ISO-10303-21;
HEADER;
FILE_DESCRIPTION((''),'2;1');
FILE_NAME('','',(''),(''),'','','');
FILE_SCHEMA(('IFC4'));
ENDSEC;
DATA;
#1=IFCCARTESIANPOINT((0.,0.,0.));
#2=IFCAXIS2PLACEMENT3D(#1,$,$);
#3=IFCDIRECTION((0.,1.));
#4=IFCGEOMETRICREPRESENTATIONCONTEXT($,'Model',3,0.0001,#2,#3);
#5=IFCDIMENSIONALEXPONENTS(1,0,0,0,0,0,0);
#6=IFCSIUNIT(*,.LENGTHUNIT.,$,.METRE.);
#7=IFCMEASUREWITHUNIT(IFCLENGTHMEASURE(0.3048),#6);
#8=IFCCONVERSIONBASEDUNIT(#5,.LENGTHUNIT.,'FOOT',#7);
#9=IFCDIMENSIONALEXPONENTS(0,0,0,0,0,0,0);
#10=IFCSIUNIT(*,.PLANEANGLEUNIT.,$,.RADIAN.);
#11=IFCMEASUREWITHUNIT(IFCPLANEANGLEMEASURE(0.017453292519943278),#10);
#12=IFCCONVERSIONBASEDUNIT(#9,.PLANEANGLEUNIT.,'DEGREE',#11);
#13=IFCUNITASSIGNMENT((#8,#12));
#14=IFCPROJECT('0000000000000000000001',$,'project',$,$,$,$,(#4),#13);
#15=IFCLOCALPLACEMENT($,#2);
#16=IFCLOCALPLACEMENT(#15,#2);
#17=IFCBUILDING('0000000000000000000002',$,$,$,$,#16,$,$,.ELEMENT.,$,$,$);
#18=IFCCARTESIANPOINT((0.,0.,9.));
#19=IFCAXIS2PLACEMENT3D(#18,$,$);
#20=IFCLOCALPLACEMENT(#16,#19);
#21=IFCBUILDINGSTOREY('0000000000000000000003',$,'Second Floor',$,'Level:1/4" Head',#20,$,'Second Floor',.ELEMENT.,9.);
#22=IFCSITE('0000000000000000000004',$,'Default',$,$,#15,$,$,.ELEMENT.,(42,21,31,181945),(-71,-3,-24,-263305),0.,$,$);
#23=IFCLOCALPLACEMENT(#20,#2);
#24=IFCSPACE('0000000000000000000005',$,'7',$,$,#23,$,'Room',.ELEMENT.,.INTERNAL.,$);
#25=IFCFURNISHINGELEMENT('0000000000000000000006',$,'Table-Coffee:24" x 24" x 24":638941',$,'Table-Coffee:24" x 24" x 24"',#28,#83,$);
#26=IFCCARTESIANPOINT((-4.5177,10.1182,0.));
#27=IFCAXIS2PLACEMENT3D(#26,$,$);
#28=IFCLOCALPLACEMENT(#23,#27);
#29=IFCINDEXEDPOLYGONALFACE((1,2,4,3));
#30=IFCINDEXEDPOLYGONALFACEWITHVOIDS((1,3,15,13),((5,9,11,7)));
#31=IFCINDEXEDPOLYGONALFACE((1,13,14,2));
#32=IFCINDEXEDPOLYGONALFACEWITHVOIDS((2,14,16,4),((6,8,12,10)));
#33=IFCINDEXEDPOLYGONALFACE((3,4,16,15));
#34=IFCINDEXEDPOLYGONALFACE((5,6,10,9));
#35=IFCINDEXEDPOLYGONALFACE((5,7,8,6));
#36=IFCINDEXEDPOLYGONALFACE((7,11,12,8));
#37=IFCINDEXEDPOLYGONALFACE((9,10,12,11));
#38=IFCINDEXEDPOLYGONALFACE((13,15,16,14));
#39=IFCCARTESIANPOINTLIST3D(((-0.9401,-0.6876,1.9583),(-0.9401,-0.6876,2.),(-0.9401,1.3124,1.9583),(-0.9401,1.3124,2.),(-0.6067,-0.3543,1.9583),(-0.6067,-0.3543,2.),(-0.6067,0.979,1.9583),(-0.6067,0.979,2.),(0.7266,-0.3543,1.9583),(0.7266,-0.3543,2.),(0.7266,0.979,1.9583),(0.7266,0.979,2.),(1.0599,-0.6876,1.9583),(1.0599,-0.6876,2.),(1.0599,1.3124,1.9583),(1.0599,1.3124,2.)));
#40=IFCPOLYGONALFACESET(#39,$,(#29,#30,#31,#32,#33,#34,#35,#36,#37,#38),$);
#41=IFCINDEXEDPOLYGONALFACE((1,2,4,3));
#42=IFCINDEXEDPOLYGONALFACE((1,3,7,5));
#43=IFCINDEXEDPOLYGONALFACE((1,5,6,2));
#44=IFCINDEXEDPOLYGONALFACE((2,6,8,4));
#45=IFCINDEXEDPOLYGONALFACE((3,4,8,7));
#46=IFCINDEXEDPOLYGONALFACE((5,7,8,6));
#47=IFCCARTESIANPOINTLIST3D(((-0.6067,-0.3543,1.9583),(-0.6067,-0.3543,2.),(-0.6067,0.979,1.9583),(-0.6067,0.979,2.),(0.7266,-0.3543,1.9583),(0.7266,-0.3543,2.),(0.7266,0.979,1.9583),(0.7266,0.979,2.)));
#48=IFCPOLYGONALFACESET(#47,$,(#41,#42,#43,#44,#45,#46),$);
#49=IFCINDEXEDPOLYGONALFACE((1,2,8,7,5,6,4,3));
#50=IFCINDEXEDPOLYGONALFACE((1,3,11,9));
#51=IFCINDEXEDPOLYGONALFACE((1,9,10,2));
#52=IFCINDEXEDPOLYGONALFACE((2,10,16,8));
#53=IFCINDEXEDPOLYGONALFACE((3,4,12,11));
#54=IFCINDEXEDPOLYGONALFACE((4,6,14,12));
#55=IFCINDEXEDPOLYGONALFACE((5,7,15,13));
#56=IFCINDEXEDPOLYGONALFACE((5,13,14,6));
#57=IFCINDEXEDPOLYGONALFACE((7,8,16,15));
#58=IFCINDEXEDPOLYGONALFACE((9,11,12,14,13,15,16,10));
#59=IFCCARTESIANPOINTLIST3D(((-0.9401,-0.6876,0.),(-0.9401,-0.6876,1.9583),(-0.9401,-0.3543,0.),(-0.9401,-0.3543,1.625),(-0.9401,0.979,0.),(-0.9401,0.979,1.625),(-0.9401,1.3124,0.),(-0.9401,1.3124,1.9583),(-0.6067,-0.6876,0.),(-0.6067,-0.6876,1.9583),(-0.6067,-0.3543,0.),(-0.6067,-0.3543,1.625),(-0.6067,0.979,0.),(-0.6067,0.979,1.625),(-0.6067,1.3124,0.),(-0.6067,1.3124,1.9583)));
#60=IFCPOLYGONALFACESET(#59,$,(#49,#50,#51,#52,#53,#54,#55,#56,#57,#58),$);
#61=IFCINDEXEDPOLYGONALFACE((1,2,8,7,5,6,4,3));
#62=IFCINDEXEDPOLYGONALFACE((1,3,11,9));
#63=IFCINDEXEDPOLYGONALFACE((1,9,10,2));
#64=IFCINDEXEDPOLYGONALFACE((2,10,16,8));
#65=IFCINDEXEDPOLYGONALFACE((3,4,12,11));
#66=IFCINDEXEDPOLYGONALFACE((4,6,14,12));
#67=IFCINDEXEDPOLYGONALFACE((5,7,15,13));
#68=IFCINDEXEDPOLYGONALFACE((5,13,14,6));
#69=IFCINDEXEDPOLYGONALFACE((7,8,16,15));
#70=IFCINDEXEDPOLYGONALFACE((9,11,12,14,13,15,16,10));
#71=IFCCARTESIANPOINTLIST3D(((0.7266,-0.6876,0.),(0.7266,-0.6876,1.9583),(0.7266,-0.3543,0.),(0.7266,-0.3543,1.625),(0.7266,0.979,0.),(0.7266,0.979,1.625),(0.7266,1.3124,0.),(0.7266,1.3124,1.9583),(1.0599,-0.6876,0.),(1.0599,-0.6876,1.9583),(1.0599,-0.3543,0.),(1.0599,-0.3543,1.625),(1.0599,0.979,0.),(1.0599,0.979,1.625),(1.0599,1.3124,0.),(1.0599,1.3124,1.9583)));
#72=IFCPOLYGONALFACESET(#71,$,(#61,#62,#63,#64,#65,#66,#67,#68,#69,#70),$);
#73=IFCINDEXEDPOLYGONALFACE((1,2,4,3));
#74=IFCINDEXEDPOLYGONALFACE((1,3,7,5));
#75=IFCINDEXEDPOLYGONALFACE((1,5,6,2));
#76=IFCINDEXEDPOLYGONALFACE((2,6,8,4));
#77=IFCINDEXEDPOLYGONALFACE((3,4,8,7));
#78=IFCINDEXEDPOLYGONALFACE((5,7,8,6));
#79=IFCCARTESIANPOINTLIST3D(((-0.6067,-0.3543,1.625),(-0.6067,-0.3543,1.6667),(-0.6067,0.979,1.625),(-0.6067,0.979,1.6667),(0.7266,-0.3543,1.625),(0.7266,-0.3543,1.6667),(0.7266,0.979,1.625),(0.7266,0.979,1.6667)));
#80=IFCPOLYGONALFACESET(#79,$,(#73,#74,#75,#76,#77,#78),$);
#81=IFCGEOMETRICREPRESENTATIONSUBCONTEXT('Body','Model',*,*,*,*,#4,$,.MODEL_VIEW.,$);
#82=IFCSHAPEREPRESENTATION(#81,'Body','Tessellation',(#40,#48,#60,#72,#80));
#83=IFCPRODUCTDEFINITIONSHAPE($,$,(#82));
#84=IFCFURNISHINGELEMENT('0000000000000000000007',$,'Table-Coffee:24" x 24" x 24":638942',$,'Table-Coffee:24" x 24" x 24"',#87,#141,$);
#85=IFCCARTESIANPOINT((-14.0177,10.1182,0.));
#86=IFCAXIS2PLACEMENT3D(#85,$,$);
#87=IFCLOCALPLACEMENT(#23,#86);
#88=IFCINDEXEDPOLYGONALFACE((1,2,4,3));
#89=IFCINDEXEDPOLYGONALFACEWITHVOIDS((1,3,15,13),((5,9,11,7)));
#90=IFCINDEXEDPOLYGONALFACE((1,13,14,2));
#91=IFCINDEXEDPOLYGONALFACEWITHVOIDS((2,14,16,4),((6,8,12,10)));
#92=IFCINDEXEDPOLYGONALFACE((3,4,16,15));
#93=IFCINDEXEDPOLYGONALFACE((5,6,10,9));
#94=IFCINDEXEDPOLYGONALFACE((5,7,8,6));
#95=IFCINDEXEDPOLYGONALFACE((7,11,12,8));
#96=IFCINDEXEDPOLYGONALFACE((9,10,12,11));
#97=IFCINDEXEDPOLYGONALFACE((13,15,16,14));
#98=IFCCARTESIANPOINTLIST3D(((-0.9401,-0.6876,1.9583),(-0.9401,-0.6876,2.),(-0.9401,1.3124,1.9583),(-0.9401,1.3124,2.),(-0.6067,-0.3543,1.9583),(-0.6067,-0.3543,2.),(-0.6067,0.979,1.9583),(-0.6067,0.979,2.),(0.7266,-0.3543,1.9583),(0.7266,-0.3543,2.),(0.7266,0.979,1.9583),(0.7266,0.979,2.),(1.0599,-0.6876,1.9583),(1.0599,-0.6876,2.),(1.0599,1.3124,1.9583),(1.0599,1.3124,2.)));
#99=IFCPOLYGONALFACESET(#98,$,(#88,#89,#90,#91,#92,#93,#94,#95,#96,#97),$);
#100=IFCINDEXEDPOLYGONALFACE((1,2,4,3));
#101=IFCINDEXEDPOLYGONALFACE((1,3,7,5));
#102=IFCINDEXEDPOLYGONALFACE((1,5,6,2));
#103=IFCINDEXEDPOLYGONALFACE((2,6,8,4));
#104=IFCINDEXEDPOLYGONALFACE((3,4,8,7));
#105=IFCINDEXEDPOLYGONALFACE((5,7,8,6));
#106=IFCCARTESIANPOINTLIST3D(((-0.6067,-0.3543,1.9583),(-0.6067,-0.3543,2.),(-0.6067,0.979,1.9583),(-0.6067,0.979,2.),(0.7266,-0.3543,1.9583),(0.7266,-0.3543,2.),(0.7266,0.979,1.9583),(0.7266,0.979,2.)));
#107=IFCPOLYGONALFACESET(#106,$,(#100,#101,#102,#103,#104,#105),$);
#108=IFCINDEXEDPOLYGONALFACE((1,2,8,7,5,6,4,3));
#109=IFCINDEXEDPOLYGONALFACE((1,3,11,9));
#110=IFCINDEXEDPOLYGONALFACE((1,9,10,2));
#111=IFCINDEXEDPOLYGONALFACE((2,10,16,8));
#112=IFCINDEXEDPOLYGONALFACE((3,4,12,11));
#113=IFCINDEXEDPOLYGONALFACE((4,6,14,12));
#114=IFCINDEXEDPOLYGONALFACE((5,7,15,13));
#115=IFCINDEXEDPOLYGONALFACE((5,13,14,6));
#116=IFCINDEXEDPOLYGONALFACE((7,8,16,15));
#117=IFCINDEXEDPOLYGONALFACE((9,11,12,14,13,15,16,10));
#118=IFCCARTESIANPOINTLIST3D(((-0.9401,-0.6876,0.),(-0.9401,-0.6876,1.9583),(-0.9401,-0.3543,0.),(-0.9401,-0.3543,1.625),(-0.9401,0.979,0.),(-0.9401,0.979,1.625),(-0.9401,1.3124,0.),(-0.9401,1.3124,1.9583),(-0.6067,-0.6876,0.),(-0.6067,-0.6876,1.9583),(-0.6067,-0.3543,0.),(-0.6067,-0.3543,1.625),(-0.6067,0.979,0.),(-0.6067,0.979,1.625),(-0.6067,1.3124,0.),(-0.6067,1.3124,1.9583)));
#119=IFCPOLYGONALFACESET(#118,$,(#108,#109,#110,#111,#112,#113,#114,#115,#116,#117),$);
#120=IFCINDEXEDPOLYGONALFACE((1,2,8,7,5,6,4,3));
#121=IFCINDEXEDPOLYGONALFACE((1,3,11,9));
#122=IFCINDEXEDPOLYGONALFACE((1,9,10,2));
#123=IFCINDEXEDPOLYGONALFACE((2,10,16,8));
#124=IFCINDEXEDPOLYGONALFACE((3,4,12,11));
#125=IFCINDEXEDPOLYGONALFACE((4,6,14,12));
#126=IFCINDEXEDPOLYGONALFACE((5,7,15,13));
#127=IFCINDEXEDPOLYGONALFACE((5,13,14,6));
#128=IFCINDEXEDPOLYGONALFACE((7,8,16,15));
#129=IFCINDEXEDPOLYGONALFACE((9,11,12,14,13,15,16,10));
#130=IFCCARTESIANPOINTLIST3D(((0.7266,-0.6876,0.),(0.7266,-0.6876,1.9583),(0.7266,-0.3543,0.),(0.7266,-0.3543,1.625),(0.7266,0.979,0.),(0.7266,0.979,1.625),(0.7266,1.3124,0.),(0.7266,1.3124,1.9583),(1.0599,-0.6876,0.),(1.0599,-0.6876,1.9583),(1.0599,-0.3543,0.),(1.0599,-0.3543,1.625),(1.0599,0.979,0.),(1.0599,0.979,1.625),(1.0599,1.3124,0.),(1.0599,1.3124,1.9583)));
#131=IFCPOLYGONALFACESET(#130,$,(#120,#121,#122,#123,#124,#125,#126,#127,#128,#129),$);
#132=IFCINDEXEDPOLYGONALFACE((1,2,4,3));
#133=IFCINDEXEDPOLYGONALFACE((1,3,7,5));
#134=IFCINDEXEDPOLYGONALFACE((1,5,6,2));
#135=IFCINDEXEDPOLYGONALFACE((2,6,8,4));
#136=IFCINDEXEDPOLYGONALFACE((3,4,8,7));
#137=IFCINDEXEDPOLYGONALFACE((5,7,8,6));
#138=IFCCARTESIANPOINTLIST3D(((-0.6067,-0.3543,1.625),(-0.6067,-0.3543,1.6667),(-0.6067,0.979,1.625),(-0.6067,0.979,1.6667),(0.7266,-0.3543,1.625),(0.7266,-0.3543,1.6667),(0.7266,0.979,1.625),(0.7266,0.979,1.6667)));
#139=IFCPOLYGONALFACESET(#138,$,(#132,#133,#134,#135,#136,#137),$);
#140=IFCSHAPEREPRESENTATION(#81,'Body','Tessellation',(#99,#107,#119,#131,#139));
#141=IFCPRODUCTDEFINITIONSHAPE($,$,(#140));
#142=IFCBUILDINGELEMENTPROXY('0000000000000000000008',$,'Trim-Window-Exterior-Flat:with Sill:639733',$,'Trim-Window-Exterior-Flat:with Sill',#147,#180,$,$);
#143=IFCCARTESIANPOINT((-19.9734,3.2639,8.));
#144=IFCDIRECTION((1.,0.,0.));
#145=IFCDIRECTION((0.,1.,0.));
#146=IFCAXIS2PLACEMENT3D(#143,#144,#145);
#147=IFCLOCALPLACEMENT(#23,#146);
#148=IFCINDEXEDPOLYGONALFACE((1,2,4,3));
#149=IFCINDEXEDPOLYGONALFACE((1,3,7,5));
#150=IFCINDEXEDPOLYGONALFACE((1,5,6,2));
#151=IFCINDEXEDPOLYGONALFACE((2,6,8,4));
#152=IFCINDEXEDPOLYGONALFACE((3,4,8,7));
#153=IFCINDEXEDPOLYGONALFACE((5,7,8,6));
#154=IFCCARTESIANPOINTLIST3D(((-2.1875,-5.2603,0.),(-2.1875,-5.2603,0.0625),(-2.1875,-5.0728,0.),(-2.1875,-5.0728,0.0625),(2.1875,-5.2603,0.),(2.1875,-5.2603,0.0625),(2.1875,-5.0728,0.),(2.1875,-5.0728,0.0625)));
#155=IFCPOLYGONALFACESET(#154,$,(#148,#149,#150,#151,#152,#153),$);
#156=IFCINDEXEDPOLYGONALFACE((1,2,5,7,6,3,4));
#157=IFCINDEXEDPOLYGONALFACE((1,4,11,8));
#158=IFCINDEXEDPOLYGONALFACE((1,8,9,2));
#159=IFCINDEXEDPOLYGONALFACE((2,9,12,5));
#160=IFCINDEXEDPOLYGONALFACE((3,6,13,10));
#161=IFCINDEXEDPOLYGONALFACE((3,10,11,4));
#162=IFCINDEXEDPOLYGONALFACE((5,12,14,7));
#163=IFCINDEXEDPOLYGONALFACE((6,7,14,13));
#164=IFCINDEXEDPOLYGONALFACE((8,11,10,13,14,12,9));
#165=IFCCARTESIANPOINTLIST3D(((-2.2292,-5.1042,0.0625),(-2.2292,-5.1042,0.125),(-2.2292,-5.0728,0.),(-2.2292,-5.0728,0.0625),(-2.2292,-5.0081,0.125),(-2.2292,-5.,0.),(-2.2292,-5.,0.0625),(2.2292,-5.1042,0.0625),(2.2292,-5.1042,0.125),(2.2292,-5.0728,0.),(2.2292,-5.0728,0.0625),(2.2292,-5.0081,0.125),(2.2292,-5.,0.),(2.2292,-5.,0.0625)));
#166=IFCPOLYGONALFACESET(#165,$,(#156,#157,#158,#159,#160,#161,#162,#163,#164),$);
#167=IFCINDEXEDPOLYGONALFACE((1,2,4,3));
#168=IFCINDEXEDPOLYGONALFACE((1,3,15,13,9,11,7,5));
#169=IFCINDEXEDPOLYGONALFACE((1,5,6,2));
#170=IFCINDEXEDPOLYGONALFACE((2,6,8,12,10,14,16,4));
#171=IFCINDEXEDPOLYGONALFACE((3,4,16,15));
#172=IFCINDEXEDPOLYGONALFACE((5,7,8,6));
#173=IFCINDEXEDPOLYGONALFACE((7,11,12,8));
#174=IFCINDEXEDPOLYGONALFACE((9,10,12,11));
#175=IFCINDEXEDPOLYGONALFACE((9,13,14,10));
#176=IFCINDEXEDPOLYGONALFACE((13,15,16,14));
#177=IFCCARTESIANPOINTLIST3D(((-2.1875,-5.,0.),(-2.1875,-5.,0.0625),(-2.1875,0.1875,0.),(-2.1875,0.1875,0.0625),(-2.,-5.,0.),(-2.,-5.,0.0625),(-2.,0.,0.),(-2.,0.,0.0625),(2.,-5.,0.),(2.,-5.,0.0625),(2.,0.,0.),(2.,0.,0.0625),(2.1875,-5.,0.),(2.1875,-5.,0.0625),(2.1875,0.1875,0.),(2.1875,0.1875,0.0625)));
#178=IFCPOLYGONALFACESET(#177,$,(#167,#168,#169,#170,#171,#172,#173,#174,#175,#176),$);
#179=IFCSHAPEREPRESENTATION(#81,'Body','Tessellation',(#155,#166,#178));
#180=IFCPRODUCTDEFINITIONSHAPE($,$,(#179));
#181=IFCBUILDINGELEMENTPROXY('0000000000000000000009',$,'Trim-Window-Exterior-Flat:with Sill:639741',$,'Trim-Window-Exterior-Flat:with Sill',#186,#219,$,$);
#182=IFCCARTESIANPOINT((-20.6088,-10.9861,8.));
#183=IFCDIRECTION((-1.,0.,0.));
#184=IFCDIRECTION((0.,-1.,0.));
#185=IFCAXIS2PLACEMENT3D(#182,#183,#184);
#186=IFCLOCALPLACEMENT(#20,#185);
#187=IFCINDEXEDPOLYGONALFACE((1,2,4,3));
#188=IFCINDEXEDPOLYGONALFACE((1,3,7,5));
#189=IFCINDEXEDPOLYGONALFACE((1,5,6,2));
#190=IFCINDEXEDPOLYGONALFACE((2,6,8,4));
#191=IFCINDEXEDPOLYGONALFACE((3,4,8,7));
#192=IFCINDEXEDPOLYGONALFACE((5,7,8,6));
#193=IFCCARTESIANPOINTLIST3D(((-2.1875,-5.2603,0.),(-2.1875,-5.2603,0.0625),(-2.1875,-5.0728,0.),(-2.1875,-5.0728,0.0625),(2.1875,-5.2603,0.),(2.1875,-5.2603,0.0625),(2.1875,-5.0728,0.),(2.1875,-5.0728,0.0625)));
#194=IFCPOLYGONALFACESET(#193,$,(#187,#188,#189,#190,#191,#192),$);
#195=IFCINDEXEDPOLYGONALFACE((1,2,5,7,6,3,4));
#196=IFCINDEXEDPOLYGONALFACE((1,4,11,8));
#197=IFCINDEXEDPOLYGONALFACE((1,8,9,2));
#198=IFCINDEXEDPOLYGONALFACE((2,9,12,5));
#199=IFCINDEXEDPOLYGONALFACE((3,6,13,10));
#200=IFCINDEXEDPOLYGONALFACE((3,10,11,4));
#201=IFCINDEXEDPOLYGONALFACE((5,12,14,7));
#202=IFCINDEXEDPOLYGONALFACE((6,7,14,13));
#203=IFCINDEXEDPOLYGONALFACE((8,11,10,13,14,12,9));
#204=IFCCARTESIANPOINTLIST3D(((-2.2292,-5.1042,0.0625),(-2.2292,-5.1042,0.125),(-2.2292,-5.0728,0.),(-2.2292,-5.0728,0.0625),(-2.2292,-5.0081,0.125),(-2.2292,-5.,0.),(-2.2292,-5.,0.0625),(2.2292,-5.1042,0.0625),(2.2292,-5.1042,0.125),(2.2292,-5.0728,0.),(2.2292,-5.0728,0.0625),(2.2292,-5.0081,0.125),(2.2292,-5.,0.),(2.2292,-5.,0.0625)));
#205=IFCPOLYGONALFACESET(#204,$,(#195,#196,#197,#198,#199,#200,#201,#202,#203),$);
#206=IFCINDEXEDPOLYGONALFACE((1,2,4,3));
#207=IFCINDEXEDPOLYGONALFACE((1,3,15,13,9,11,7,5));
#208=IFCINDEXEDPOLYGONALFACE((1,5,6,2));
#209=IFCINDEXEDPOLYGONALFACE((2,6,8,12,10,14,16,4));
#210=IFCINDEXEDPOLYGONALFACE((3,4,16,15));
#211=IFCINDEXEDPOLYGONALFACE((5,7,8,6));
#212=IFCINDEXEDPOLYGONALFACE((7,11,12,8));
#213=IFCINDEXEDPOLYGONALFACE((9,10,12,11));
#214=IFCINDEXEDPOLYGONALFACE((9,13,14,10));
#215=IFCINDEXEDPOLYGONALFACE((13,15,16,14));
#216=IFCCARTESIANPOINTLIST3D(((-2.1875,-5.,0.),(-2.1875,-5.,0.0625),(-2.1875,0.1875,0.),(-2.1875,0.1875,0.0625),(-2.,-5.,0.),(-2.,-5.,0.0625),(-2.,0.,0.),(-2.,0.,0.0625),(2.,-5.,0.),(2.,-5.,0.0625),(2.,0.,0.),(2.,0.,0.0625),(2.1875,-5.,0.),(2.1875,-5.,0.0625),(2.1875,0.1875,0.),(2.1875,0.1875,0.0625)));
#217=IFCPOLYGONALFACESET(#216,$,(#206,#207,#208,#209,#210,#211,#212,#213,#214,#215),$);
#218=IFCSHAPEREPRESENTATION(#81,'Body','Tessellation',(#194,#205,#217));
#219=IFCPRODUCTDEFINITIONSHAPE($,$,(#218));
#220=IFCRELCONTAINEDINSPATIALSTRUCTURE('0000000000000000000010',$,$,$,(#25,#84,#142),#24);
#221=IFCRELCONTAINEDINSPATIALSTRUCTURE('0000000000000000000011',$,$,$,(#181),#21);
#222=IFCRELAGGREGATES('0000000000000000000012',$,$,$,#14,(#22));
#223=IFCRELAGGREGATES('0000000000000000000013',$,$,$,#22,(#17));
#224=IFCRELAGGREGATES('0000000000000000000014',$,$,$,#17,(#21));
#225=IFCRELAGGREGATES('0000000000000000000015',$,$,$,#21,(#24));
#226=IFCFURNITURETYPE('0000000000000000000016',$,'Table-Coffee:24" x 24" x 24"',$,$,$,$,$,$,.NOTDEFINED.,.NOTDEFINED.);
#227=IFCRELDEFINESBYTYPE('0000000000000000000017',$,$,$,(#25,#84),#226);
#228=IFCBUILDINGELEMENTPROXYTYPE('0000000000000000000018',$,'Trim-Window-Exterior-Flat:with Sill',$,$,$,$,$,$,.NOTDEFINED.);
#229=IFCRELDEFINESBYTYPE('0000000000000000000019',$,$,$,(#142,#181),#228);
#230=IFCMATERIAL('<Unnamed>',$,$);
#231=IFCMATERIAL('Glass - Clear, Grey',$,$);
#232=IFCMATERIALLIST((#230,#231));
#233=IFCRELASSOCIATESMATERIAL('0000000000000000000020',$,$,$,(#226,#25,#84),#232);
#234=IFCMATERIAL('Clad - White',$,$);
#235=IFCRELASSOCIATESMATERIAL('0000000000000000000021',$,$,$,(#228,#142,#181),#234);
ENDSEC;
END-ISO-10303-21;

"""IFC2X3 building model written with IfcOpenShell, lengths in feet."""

from ifc_helpers import new_model, entity, si_unit, converted_unit, direction, frame, frame_2d, origin, origin_2d_with_axis, place, context, subcontext, project, spatial, polyline, rectangle, outline, extrude, source, transform, mapped, material, material_list, type_object, type_shapes, element, save


model = new_model("IFC2X3")

# Units and contexts
model_context = context("Model", 3, precision=0.0001, world=origin(), true_north=direction((0.0, 1.0)))
body_context = subcontext(model_context, "Body", "Model", "MODEL_VIEW")
ifc_project = project(units=[converted_unit("LENGTHUNIT", "FOOT", entity("IfcLengthMeasure", 0.3048), si_unit("LENGTHUNIT", "METRE"), dimensions=[1, 0, 0, 0, 0, 0, 0]), converted_unit("PLANEANGLEUNIT", "DEGREE", entity("IfcPlaneAngleMeasure", 0.017453292519943278), si_unit("PLANEANGLEUNIT", "RADIAN"), dimensions=[0, 0, 0, 0, 0, 0, 0])], contexts=[model_context])

# Site, building, storey
site_placement = place(None, origin())
site = spatial("IfcSite", under=ifc_project, at=site_placement, Name="Default", CompositionType="ELEMENT", RefLatitude=(42, 21, 31, 181945), RefLongitude=(-71, -3, -24, -263305), RefElevation=0.0)
building_placement = place(site_placement, origin())
building = spatial("IfcBuilding", under=site, at=building_placement, CompositionType="ELEMENT")
storey_placement = place(building_placement, frame((0.0, 0.0, 9.0)))
storey = spatial("IfcBuildingStorey", under=building, at=storey_placement, Name="Second Floor", ObjectType="Level:1/4\" Head", LongName="Second Floor", CompositionType="ELEMENT", Elevation=9.0)

# Shared definitions
space_placement = place(storey_placement, origin())
space = spatial("IfcSpace", under=storey, at=space_placement, Name="7", LongName="Room", CompositionType="ELEMENT", InteriorOrExteriorSpace="INTERNAL")

# Furnishing elements
ifc_material_1 = material(Name="<Unnamed>")
ifc_material_2 = material(Name="Glass - Clear, Grey")
ifc_material_list_1 = material_list([ifc_material_1, ifc_material_2])
furniture_type_1 = type_object("IfcFurnitureType", Name="Table-Coffee:24\" x 24\" x 24\"", AssemblyPlace="NOTDEFINED", material=ifc_material_list_1)
shared_shape_1 = source(origin(), body_context, "Body", "SweptSolid", [
    extrude(outline(polyline([(-1.0, -1.0), (1.0, -1.0), (1.0, 1.0), (-1.0, 1.0), (-1.0, -1.0)]), holes=[polyline([(-0.6667, -0.6667), (-0.6667, 0.6667), (0.6667, 0.6667), (0.6667, -0.6667), (-0.6667, -0.6667)])]), frame((0.0599, 0.3124, 1.9583), z_axis=(0.0, 0.0, 1.0), x_axis=(-1.0, 0.0, 0.0)), (0.0, 0.0, 1.0), 0.0417),
    extrude(rectangle(XDim=1.3333, YDim=1.3333, at=origin_2d_with_axis()), frame((0.0599, 0.3124, 1.9583), z_axis=(0.0, 0.0, 1.0), x_axis=(-1.0, 0.0, 0.0)), (0.0, 0.0, 1.0), 0.0417),
    extrude(outline(polyline([(-1.0, -1.0625), (1.0, -1.0625), (1.0, 0.8958), (0.6667, 0.8958), (0.6667, -0.7292), (-0.6667, -0.7292), (-0.6667, 0.8958), (-1.0, 0.8958), (-1.0, -1.0625)])), frame((-0.9401, 0.3124, 0.8958), z_axis=(1.0, 0.0, 0.0), x_axis=(0.0, -1.0, 0.0)), (0.0, 0.0, 1.0), 0.3333),
    extrude(outline(polyline([(-0.8958, -1.0), (1.0625, -1.0), (1.0625, 1.0), (-0.8958, 1.0), (-0.8958, 0.6667), (0.7292, 0.6667), (0.7292, -0.6667), (-0.8958, -0.6667), (-0.8958, -1.0)])), frame((0.7266, 0.3124, 0.8958), z_axis=(1.0, 0.0, 0.0), x_axis=(0.0, 0.0, 1.0)), (0.0, 0.0, 1.0), 0.3333),
    extrude(rectangle(XDim=1.3333, YDim=1.3333, at=origin_2d_with_axis()), frame((0.0599, 0.3124, 1.625), z_axis=(0.0, 0.0, 1.0), x_axis=(-1.0, 0.0, 0.0)), (0.0, 0.0, 1.0), 0.0417),
])
type_shapes(furniture_type_1, [shared_shape_1])
for number, where, name in (
    (1, (-4.5177, 10.1182, 0.0), "Table-Coffee:24\" x 24\" x 24\":638941"),
    (2, (-14.0177, 10.1182, 0.0), "Table-Coffee:24\" x 24\" x 24\":638942"),
):
    element("IfcFurnishingElement", number, at=place(space_placement, frame(where)), inside=space, type_object=furniture_type_1, material=ifc_material_list_1, Name=name, ObjectType="Table-Coffee:24\" x 24\" x 24\"", context=body_context, shape_type="MappedRepresentation", body=[
        mapped(shared_shape_1, transform((0.0, 0.0, 0.0), scale=1.0)),
    ])

# Building element proxies
ifc_material_3 = material(Name="Clad - White")
building_element_proxy_type_1 = type_object("IfcBuildingElementProxyType", Name="Trim-Window-Exterior-Flat:with Sill", PredefinedType="NOTDEFINED", material=ifc_material_3)
shared_shape_2 = source(origin(), body_context, "Body", "SweptSolid", [
    extrude(rectangle(XDim=4.375, YDim=0.1875, at=frame_2d((0.0, 0.0), x_axis=(1.0, 0.0))), frame((0.0, -5.1665, 0.0), z_axis=(0.0, 0.0, 1.0), x_axis=(-1.0, 0.0, 0.0)), (0.0, 0.0, 1.0), 0.0625),
    extrude(outline(polyline([(-0.0625, -0.0525), (0.0, -0.0525), (0.0, -0.0211), (0.0625, -0.0211), (0.0625, 0.0517), (0.0, 0.0517), (-0.0625, 0.0436), (-0.0625, -0.0525)])), frame((-2.2292, -5.0517, 0.0625), z_axis=(1.0, 0.0, 0.0), x_axis=(0.0, 0.0, -1.0)), (0.0, 0.0, 1.0), 4.4583),
    extrude(outline(polyline([(-2.6406, -2.1875), (2.5469, -2.1875), (2.5469, -2.0), (-2.4531, -2.0), (-2.4531, 2.0), (2.5469, 2.0), (2.5469, 2.1875), (-2.6406, 2.1875), (-2.6406, -2.1875)])), frame((0.0, -2.4531, 0.0), z_axis=(0.0, 0.0, 1.0), x_axis=(0.0, -1.0, 0.0)), (0.0, 0.0, 1.0), 0.0625),
])
type_shapes(building_element_proxy_type_1, [shared_shape_2])
proxy_1_placement = place(space_placement, frame((-19.9734, 3.2639, 8.0), z_axis=(1.0, 0.0, 0.0), x_axis=(0.0, 1.0, 0.0)))
element("IfcBuildingElementProxy", 3, at=proxy_1_placement, inside=space, type_object=building_element_proxy_type_1, material=ifc_material_3, Name="Trim-Window-Exterior-Flat:with Sill:639733", ObjectType="Trim-Window-Exterior-Flat:with Sill", context=body_context, shape_type="MappedRepresentation", body=[
    mapped(shared_shape_2, transform((0.0, 0.0, 0.0), scale=1.0)),
])
proxy_2_placement = place(storey_placement, frame((-20.6088, -10.9861, 8.0), z_axis=(-1.0, 0.0, 0.0), x_axis=(0.0, -1.0, 0.0)))
element("IfcBuildingElementProxy", 4, at=proxy_2_placement, inside=storey, type_object=building_element_proxy_type_1, material=ifc_material_3, Name="Trim-Window-Exterior-Flat:with Sill:639741", ObjectType="Trim-Window-Exterior-Flat:with Sill", context=body_context, shape_type="MappedRepresentation", body=[
    mapped(shared_shape_2, transform((0.0, 0.0, 0.0), scale=1.0)),
])

save(model, "model.ifc")
